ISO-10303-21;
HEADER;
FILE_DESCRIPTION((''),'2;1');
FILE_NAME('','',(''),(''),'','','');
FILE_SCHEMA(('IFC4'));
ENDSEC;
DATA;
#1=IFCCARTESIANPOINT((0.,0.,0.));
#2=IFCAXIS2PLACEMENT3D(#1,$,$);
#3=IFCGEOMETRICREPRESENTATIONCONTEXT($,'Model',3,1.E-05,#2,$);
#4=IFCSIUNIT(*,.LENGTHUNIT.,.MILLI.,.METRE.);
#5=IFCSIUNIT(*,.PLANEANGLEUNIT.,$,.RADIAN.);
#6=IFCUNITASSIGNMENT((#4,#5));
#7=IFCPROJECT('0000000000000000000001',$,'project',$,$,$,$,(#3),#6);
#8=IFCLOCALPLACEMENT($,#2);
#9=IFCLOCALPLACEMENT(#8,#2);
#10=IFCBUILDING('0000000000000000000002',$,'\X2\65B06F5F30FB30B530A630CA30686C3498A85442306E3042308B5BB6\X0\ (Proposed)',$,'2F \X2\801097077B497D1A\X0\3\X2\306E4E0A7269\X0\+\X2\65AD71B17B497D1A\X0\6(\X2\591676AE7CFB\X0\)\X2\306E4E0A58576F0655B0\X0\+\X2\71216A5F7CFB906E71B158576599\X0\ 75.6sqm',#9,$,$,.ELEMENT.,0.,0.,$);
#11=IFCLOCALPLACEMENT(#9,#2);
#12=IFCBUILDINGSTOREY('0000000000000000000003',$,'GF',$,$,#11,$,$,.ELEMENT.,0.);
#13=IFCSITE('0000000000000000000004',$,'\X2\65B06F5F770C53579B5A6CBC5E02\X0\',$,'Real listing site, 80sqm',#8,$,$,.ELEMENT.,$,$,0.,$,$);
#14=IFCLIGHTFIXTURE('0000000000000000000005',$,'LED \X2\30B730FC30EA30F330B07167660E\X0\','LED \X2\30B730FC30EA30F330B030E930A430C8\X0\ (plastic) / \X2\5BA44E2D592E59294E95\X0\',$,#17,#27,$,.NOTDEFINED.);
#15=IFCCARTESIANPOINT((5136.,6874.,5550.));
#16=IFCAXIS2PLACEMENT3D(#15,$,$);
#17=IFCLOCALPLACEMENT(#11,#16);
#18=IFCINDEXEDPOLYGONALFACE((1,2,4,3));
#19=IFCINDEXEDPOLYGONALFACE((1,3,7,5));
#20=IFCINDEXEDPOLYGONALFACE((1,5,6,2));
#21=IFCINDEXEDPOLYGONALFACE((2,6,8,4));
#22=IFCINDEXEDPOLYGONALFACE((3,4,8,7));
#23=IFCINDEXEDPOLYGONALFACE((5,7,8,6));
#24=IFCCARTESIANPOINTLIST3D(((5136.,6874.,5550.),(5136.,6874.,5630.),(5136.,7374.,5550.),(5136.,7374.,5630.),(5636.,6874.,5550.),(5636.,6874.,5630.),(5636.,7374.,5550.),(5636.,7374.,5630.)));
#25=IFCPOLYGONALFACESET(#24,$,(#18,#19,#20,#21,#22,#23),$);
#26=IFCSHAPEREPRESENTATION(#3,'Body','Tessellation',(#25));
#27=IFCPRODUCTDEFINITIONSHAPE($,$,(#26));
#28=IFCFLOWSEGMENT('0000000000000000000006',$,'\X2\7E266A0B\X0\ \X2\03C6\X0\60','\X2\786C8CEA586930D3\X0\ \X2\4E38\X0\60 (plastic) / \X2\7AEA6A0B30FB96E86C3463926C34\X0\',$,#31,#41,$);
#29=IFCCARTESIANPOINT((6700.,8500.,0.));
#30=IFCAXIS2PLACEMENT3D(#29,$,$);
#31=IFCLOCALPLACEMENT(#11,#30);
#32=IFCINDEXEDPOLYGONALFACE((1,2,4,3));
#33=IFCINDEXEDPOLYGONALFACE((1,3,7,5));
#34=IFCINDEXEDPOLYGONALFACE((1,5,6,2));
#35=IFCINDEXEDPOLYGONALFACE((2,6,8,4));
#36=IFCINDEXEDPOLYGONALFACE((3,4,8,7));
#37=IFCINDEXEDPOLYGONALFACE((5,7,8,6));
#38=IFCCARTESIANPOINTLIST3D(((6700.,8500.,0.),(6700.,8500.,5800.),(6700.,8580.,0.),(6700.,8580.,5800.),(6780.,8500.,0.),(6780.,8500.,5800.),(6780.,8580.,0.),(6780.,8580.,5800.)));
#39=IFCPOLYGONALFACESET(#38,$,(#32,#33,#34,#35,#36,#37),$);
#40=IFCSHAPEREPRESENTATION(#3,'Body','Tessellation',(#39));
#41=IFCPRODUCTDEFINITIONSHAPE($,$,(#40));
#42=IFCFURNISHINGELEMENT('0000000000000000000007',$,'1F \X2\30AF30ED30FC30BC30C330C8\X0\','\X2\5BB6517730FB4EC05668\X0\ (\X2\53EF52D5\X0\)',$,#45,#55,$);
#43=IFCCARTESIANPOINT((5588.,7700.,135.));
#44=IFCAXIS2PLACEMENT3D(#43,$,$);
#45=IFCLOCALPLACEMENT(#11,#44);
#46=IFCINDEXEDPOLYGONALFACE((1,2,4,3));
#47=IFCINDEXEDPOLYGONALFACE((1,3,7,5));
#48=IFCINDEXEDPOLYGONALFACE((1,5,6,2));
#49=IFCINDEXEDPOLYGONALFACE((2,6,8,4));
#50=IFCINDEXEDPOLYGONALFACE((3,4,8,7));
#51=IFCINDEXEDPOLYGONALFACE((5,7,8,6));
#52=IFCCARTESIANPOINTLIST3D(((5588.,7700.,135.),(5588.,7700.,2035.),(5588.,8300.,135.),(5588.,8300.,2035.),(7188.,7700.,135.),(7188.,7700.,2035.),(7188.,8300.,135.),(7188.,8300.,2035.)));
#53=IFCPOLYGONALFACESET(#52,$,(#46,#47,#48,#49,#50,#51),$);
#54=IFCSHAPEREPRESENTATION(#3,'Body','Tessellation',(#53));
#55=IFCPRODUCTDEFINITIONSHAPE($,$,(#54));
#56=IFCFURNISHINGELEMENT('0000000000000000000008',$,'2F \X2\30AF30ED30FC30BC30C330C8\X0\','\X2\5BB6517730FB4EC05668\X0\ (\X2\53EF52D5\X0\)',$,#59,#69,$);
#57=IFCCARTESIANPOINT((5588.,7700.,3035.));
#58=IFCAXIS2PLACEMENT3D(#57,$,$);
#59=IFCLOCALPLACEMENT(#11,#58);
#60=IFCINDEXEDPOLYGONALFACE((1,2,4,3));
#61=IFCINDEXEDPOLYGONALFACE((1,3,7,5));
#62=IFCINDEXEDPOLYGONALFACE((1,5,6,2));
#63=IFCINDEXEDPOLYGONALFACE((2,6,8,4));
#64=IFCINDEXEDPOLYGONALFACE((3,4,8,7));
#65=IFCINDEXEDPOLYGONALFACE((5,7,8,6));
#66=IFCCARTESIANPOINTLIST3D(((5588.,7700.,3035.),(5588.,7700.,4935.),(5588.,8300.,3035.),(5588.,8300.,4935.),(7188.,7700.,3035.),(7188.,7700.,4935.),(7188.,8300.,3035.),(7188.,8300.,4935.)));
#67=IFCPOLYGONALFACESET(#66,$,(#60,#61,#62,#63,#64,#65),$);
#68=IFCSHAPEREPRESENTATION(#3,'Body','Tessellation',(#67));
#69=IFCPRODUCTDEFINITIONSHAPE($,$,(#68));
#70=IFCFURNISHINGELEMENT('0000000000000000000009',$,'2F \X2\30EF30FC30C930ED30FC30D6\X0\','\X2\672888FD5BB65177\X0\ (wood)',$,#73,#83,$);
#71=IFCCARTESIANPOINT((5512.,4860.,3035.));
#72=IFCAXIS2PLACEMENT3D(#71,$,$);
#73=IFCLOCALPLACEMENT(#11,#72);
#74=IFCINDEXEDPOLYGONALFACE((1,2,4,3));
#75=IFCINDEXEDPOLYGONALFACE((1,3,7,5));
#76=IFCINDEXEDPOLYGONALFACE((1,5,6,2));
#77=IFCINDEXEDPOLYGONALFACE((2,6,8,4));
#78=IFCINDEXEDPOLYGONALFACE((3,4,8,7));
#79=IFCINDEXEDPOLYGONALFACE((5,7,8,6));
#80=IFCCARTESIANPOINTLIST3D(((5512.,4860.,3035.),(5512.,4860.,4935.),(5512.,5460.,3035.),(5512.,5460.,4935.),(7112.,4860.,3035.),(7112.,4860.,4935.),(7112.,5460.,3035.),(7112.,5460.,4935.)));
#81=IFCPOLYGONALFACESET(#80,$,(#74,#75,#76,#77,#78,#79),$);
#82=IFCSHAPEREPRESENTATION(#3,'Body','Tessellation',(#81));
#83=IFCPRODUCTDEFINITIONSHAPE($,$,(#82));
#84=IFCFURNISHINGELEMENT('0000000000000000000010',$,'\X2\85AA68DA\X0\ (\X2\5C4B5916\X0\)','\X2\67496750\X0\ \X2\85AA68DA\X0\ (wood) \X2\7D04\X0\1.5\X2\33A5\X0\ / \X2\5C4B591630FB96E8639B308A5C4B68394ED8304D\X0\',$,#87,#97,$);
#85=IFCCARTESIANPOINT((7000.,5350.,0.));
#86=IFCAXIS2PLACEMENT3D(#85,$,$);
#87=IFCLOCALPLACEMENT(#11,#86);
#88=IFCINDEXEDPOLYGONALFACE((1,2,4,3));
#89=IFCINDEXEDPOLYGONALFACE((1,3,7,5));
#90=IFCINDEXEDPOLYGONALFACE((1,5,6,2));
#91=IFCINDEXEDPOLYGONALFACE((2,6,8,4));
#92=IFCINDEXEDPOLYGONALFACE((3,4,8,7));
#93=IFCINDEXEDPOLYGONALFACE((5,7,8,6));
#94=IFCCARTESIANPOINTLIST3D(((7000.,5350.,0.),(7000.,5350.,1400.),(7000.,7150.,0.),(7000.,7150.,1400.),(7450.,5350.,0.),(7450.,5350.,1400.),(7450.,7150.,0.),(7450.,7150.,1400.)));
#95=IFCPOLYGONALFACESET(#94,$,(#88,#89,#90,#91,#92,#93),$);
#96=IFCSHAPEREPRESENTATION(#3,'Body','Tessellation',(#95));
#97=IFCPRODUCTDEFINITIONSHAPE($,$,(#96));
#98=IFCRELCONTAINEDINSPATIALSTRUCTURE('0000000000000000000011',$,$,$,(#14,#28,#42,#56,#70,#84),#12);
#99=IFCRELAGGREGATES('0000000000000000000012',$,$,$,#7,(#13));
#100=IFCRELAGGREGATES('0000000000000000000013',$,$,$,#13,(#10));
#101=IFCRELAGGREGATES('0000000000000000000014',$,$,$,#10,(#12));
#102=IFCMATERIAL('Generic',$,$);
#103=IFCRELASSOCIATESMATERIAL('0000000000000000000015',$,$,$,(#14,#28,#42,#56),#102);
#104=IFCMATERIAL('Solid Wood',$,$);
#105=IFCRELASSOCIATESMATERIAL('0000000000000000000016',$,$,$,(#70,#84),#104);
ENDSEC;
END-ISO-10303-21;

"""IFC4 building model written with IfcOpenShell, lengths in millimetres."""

from ifc_helpers import new_model, si_unit, frame, frame_2d, origin, place, context, project, spatial, rectangle, extrude, material, element, save


model = new_model("IFC4")

# Units and contexts
model_context = context("Model", 3, precision=1e-05, world=origin())
ifc_project = project(units=[si_unit("LENGTHUNIT", "METRE", prefix="MILLI"), si_unit("PLANEANGLEUNIT", "RADIAN")], contexts=[model_context])

# Site, building, storey
site_placement = place(None, origin())
site = spatial("IfcSite", under=ifc_project, at=site_placement, Name="新潟県南魚沼市", ObjectType="Real listing site, 80sqm", CompositionType="ELEMENT", RefElevation=0.0)
building_placement = place(site_placement, origin())
building = spatial("IfcBuilding", under=site, at=building_placement, Name="新潟・サウナと水風呂のある家 (Proposed)", ObjectType="2F 耐震等級3の上物+断熱等級6(外皮系)の上塗漆喰+無機系遮熱塗料 75.6sqm", CompositionType="ELEMENT", ElevationOfRefHeight=0.0, ElevationOfTerrain=0.0)
storey_placement = place(building_placement, origin())
storey = spatial("IfcBuildingStorey", under=building, at=storey_placement, Name="GF", CompositionType="ELEMENT", Elevation=0.0)

# Shared definitions
ifc_material_1 = material(Name="Solid Wood")

# Shared definitions
ifc_material_2 = material(Name="Generic")

# Light fixture
light_fixture_1_placement = place(storey_placement, frame((5136.0, 6874.0, 5550.0)))
element("IfcLightFixture", 1, at=light_fixture_1_placement, inside=storey, material=ifc_material_2, Name="LED シーリング照明", Description="LED シーリングライト (plastic) / 室中央天井", PredefinedType="NOTDEFINED", context=model_context, shape_type="SweptSolid", body=[
    extrude(rectangle(XDim=500.0, YDim=500.0, at=frame_2d((250.0, 250.0))), frame((5136.0, 6874.0, 5550.0)), (0.0, 0.0, 1.0), 80.0),
])

# Flow segment
flow_segment_placement = place(storey_placement, frame((6700.0, 8500.0, 0.0)))
element("IfcFlowSegment", 2, at=flow_segment_placement, inside=storey, material=ifc_material_2, Name="縦樋 φ60", Description="硬質塩ビ 丸60 (plastic) / 竪樋・雨水排水", context=model_context, shape_type="SweptSolid", body=[
    extrude(rectangle(XDim=80.0, YDim=80.0, at=frame_2d((40.0, 40.0))), frame((6700.0, 8500.0, 0.0)), (0.0, 0.0, 1.0), 5800.0),
])

# Furnishing elements
furnishing_1_placement = place(storey_placement, frame((5588.0, 7700.0, 135.0)))
element("IfcFurnishingElement", 3, at=furnishing_1_placement, inside=storey, material=ifc_material_2, Name="1F クローゼット", Description="家具・什器 (可動)", context=model_context, shape_type="SweptSolid", body=[
    extrude(rectangle(XDim=1600.0, YDim=600.0, at=frame_2d((800.0, 300.0))), frame((5588.0, 7700.0, 135.0)), (0.0, 0.0, 1.0), 1900.0),
])
furnishing_2_placement = place(storey_placement, frame((5588.0, 7700.0, 3035.0)))
element("IfcFurnishingElement", 4, at=furnishing_2_placement, inside=storey, material=ifc_material_2, Name="2F クローゼット", Description="家具・什器 (可動)", context=model_context, shape_type="SweptSolid", body=[
    extrude(rectangle(XDim=1600.0, YDim=600.0, at=frame_2d((800.0, 300.0))), frame((5588.0, 7700.0, 3035.0)), (0.0, 0.0, 1.0), 1900.0),
])
furnishing_3_placement = place(storey_placement, frame((5512.0, 4860.0, 3035.0)))
element("IfcFurnishingElement", 5, at=furnishing_3_placement, inside=storey, material=ifc_material_1, Name="2F ワードローブ", Description="木製家具 (wood)", context=model_context, shape_type="SweptSolid", body=[
    extrude(rectangle(XDim=1600.0, YDim=600.0, at=frame_2d((800.0, 300.0))), frame((5512.0, 4860.0, 3035.0)), (0.0, 0.0, 1.0), 1900.0),
])
furnishing_4_placement = place(storey_placement, frame((7000.0, 5350.0, 0.0)))
element("IfcFurnishingElement", 6, at=furnishing_4_placement, inside=storey, material=ifc_material_1, Name="薪棚 (屋外)", Description="杉材 薪棚 (wood) 約1.5㎥ / 屋外・雨掛り屋根付き", context=model_context, shape_type="SweptSolid", body=[
    extrude(rectangle(XDim=450.0, YDim=1800.0, at=frame_2d((225.0, 900.0))), frame((7000.0, 5350.0, 0.0)), (0.0, 0.0, 1.0), 1400.0),
])

save(model, "model.ifc")
